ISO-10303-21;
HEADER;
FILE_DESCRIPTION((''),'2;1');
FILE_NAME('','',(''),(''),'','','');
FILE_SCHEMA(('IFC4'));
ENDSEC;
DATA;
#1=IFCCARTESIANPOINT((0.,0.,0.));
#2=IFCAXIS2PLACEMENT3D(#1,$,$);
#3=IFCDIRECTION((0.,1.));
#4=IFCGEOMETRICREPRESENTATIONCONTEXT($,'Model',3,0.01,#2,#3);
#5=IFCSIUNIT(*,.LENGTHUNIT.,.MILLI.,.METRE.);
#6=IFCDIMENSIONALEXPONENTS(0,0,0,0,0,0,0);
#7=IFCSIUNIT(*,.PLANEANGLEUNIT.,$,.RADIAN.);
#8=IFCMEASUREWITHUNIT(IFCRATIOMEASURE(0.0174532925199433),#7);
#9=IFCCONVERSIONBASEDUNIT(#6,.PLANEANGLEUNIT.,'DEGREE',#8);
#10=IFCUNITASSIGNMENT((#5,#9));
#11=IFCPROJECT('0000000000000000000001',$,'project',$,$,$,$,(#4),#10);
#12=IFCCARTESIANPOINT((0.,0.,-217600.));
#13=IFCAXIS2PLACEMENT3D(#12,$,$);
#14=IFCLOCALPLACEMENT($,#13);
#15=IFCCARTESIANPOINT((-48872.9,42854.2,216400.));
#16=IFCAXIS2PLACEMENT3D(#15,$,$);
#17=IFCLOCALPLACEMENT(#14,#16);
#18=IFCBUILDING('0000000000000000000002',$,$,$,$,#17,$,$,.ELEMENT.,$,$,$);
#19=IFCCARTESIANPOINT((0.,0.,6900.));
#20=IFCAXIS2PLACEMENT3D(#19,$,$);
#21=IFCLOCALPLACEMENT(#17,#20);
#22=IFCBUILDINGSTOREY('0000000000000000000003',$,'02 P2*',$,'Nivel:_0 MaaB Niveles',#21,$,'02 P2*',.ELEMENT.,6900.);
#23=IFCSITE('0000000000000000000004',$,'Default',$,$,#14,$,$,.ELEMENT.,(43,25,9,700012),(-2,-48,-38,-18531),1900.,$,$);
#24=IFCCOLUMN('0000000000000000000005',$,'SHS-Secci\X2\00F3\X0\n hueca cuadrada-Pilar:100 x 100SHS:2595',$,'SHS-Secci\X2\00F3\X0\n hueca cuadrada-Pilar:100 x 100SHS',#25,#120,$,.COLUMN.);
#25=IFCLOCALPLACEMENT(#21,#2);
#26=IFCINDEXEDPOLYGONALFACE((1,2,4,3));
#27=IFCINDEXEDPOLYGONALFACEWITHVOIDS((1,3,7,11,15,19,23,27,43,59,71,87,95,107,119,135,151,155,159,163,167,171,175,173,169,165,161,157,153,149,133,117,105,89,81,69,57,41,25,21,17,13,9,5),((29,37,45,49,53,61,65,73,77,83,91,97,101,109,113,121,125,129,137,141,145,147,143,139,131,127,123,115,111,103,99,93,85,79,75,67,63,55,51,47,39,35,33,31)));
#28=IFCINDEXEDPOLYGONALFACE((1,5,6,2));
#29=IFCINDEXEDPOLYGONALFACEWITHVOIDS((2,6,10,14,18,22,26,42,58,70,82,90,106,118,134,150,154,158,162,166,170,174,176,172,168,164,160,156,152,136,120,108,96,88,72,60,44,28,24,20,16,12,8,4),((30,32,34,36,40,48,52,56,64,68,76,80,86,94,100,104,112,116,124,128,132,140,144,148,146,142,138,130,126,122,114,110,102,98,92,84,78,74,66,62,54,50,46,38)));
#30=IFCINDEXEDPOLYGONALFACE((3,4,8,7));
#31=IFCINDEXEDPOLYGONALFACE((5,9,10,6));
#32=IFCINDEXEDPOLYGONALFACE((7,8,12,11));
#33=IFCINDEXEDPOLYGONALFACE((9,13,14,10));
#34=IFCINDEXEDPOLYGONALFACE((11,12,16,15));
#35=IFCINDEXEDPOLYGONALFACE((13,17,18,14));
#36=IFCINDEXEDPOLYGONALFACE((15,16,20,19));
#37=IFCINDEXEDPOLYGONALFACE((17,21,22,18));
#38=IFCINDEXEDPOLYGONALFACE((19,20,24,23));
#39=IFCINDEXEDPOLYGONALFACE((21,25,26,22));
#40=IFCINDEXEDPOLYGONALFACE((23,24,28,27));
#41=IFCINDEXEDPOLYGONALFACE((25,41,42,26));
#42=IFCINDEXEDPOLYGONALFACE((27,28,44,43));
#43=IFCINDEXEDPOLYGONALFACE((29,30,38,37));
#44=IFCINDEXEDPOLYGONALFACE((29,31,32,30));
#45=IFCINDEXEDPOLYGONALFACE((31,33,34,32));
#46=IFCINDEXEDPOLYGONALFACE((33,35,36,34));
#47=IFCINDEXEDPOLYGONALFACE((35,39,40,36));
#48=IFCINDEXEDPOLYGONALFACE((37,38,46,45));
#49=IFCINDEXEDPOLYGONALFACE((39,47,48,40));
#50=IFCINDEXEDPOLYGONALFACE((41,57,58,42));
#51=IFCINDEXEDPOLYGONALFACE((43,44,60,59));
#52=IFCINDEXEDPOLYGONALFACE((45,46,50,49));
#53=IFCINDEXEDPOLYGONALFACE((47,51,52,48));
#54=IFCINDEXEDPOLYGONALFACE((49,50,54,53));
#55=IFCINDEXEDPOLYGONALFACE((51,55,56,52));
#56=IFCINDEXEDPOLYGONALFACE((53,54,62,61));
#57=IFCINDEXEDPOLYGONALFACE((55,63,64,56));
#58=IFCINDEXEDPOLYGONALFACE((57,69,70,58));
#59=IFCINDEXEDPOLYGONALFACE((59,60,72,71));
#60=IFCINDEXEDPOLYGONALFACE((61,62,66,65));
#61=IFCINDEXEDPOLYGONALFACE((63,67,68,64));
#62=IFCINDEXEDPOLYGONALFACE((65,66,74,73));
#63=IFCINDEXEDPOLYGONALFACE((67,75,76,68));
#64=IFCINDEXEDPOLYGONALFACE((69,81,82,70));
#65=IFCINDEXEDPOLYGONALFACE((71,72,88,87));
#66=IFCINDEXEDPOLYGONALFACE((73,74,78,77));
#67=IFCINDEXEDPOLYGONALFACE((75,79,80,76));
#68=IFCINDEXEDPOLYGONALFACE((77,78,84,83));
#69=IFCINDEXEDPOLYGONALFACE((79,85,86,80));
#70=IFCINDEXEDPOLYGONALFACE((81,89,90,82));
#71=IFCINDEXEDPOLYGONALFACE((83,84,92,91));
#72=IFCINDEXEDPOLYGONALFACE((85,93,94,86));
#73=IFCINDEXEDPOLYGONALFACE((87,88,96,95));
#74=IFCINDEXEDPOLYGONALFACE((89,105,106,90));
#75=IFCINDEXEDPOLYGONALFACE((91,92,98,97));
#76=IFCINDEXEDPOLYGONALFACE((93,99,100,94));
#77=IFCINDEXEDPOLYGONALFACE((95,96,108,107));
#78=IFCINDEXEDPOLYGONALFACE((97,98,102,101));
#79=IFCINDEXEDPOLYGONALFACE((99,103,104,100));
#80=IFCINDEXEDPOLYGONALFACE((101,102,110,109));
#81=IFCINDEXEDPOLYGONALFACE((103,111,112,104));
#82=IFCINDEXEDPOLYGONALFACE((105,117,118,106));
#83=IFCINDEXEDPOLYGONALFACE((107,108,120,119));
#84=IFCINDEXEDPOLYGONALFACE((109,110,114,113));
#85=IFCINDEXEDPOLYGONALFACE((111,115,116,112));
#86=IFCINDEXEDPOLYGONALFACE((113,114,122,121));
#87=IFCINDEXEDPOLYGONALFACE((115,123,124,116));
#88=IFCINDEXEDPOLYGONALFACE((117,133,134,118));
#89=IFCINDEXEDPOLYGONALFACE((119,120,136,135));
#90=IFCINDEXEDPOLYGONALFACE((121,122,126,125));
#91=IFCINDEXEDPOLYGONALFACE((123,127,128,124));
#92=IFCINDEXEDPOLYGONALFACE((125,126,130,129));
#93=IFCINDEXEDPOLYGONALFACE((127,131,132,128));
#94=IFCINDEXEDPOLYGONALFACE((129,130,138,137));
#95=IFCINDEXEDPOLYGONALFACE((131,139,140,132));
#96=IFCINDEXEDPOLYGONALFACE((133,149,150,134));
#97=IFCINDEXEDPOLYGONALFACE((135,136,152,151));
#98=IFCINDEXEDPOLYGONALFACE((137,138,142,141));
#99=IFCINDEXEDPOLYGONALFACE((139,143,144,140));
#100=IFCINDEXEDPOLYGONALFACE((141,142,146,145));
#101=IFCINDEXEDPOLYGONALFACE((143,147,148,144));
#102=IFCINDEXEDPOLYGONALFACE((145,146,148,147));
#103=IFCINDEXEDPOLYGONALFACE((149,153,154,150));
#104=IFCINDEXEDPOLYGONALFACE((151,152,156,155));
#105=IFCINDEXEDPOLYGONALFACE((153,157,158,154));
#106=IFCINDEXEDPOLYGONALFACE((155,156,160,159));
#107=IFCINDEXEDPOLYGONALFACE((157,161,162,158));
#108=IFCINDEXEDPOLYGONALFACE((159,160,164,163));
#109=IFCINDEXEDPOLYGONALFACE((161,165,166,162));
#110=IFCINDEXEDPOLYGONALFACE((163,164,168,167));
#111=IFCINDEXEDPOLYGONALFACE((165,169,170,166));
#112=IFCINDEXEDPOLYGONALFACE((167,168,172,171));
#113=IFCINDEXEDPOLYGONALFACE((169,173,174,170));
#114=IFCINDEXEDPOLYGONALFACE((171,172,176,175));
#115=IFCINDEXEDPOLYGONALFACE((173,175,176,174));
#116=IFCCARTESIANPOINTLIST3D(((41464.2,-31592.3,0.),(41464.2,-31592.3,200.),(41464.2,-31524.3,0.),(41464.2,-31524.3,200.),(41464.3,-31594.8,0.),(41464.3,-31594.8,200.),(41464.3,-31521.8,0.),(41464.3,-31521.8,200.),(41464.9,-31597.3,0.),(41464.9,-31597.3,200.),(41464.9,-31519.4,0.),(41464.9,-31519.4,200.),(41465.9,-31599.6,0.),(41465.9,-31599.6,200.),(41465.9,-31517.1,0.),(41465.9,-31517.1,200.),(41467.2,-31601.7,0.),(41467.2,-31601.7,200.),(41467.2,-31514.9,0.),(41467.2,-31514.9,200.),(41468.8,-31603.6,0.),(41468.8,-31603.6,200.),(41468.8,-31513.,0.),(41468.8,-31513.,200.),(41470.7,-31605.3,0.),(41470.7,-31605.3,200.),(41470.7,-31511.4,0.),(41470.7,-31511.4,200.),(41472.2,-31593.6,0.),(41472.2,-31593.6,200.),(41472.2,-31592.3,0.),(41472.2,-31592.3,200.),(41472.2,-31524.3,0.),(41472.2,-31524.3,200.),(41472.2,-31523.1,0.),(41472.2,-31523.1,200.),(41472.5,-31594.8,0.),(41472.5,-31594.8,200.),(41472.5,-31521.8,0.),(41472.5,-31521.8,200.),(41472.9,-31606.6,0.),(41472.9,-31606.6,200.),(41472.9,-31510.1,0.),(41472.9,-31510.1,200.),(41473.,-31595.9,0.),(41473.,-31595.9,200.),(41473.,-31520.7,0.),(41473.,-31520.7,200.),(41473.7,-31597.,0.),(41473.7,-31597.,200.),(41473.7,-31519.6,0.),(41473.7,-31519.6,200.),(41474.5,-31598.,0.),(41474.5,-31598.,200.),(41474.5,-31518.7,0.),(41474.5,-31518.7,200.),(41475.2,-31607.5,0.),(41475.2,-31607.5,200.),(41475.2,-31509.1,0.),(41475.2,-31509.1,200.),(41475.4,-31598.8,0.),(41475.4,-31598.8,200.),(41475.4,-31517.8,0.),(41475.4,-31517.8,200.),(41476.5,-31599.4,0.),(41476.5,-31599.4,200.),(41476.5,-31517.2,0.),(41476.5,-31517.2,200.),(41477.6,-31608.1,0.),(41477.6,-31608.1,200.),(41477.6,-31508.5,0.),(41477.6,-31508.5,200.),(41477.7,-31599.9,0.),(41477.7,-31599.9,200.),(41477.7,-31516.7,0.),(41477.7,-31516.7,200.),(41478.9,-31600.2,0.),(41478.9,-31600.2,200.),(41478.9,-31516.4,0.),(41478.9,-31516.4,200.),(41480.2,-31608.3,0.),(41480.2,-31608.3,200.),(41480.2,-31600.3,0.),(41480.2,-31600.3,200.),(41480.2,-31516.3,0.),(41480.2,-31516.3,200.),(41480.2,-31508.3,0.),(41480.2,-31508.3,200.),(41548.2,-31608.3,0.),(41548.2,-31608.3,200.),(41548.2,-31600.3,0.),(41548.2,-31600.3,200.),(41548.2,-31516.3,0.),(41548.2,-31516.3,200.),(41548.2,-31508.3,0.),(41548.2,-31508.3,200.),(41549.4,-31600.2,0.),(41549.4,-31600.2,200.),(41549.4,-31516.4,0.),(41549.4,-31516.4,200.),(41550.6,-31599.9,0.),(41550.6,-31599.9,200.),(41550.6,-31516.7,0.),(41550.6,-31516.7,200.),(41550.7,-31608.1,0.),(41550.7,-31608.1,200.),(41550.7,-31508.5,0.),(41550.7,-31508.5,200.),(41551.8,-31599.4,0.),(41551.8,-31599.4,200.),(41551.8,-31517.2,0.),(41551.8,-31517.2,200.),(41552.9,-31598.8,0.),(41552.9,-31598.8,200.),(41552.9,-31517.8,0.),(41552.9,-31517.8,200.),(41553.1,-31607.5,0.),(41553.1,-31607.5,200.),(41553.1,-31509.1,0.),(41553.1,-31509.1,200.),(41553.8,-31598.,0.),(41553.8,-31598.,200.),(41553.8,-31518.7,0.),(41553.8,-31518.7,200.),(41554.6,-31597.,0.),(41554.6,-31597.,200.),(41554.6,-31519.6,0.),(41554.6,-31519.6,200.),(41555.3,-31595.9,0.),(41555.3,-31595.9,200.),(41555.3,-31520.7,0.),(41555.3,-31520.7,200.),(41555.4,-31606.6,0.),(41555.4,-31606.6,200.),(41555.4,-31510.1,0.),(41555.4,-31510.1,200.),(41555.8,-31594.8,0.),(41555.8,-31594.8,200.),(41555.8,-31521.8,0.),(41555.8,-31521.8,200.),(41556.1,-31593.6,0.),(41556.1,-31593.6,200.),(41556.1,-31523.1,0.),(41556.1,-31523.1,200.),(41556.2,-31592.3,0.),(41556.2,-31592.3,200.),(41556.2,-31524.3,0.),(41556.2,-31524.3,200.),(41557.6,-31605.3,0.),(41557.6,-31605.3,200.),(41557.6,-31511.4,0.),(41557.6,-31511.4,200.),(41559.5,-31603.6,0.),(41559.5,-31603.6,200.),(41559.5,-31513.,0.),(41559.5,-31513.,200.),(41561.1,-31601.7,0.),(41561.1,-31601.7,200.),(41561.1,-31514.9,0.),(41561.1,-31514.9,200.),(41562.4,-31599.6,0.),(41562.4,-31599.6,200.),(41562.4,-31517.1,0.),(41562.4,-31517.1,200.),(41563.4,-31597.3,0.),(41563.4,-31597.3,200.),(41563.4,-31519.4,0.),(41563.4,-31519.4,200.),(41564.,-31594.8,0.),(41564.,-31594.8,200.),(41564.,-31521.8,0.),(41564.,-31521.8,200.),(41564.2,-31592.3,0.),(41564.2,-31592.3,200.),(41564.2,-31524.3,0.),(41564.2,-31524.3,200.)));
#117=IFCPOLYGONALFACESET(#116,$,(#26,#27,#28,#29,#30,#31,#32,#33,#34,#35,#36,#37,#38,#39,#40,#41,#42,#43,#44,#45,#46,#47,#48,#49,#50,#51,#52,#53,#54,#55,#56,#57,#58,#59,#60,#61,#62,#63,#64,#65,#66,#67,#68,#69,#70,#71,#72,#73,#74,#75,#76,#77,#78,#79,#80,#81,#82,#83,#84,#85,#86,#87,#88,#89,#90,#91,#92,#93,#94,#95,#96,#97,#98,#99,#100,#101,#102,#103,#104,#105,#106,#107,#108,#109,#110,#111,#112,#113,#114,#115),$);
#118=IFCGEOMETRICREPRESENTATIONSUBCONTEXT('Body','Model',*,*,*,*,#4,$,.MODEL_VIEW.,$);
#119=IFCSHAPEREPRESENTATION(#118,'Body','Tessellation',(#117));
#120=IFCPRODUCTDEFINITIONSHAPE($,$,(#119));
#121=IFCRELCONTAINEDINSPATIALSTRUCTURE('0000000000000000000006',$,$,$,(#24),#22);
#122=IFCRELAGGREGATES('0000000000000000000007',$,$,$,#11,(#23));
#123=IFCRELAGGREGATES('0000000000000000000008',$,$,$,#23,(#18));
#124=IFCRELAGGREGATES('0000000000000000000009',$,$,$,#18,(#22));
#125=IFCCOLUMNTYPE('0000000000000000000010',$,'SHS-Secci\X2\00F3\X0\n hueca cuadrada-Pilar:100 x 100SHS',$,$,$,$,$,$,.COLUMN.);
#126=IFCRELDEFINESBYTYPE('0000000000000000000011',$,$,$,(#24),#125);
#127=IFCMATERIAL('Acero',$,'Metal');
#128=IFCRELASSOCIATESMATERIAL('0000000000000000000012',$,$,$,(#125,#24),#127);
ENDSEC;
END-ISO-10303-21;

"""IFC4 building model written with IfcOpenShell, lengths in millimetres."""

from ifc_helpers import new_model, entity, si_unit, converted_unit, direction, frame, origin, place, context, subcontext, project, spatial, indexed_curve, outline, extrude, source, transform, mapped, material, type_object, type_shapes, element, save


model = new_model("IFC4")

# Units and contexts
model_context = context("Model", 3, precision=0.01, world=origin(), true_north=direction((0.0, 1.0)))
body_context = subcontext(model_context, "Body", "Model", "MODEL_VIEW")
ifc_project = project(units=[si_unit("LENGTHUNIT", "METRE", prefix="MILLI"), converted_unit("PLANEANGLEUNIT", "DEGREE", entity("IfcRatioMeasure", 0.0174532925199433), si_unit("PLANEANGLEUNIT", "RADIAN"), dimensions=[0, 0, 0, 0, 0, 0, 0])], contexts=[model_context])

# Site, building, storey
site_placement = place(None, frame((0.0, 0.0, -217600.0)))
site = spatial("IfcSite", under=ifc_project, at=site_placement, Name="Default", CompositionType="ELEMENT", RefLatitude=(43, 25, 9, 700012), RefLongitude=(-2, -48, -38, -18531), RefElevation=1900.0)
building_placement = place(site_placement, frame((-48872.9, 42854.2, 216400.0)))
building = spatial("IfcBuilding", under=site, at=building_placement, CompositionType="ELEMENT")
storey_placement = place(building_placement, frame((0.0, 0.0, 6900.0)))
storey = spatial("IfcBuildingStorey", under=building, at=storey_placement, Name="02 P2*", ObjectType="Nivel:_0 MaaB Niveles", LongName="02 P2*", CompositionType="ELEMENT", Elevation=6900.0)

# Column
ifc_material_1 = material(Name="Acero", Category="Metal")
column_type_1 = type_object("IfcColumnType", Name="SHS-Sección hueca cuadrada-Pilar:100 x 100SHS", PredefinedType="COLUMN", material=ifc_material_1)
shared_shape_1 = source(origin(), body_context, "Body", "SweptSolid", [
    extrude(outline(indexed_curve([(-34.0, -50.0), (34.0, -50.0), (36.5, -49.8), (38.9, -49.2), (41.3, -48.3), (43.4, -46.9), (45.3, -45.3), (46.9, -43.4), (48.3, -41.3), (49.2, -38.9), (49.8, -36.5), (50.0, -34.0), (50.0, 34.0), (49.8, 36.5), (49.2, 38.9), (48.3, 41.3), (46.9, 43.4), (45.3, 45.3), (43.4, 46.9), (41.3, 48.3), (38.9, 49.2), (36.5, 49.8), (34.0, 50.0), (-34.0, 50.0), (-36.5, 49.8), (-38.9, 49.2), (-41.3, 48.3), (-43.4, 46.9), (-45.3, 45.3), (-46.9, 43.4), (-48.3, 41.3), (-49.2, 38.9), (-49.8, 36.5), (-50.0, 34.0), (-50.0, -34.0), (-49.8, -36.5), (-49.2, -38.9), (-48.3, -41.3), (-46.9, -43.4), (-45.3, -45.3), (-43.4, -46.9), (-41.3, -48.3), (-38.9, -49.2), (-36.5, -49.8), (-34.0, -50.0)], self_intersect=False), holes=[indexed_curve([(-42.0, 34.0), (-41.9, 35.3), (-41.6, 36.5), (-41.1, 37.6), (-40.5, 38.7), (-39.7, 39.7), (-38.7, 40.5), (-37.6, 41.1), (-36.5, 41.6), (-35.3, 41.9), (-34.0, 42.0), (34.0, 42.0), (35.3, 41.9), (36.5, 41.6), (37.6, 41.1), (38.7, 40.5), (39.7, 39.7), (40.5, 38.7), (41.1, 37.6), (41.6, 36.5), (41.9, 35.3), (42.0, 34.0), (42.0, -34.0), (41.9, -35.3), (41.6, -36.5), (41.1, -37.6), (40.5, -38.7), (39.7, -39.7), (38.7, -40.5), (37.6, -41.1), (36.5, -41.6), (35.3, -41.9), (34.0, -42.0), (-34.0, -42.0), (-35.3, -41.9), (-36.5, -41.6), (-37.6, -41.1), (-38.7, -40.5), (-39.7, -39.7), (-40.5, -38.7), (-41.1, -37.6), (-41.6, -36.5), (-41.9, -35.3), (-42.0, -34.0), (-42.0, 34.0)], self_intersect=False)]), frame((0.0, 0.0, 6900.0), z_axis=(0.0, 0.0, 1.0), x_axis=(0.0, 1.0, 0.0)), (0.0, 0.0, 1.0), 200.0),
])
type_shapes(column_type_1, [shared_shape_1])
column_1_placement = place(storey_placement, frame((41514.2, -31558.3, -6900.0), z_axis=(0.0, 0.0, 1.0), x_axis=(0.0, -1.0, 0.0)))
element("IfcColumn", 1, at=column_1_placement, inside=storey, type_object=column_type_1, material=ifc_material_1, Name="SHS-Sección hueca cuadrada-Pilar:100 x 100SHS:2595", ObjectType="SHS-Sección hueca cuadrada-Pilar:100 x 100SHS", PredefinedType="COLUMN", context=body_context, shape_type="MappedRepresentation", body=[
    mapped(shared_shape_1, transform((0.0, 0.0, 0.0), scale=1.0)),
])

save(model, "model.ifc")
